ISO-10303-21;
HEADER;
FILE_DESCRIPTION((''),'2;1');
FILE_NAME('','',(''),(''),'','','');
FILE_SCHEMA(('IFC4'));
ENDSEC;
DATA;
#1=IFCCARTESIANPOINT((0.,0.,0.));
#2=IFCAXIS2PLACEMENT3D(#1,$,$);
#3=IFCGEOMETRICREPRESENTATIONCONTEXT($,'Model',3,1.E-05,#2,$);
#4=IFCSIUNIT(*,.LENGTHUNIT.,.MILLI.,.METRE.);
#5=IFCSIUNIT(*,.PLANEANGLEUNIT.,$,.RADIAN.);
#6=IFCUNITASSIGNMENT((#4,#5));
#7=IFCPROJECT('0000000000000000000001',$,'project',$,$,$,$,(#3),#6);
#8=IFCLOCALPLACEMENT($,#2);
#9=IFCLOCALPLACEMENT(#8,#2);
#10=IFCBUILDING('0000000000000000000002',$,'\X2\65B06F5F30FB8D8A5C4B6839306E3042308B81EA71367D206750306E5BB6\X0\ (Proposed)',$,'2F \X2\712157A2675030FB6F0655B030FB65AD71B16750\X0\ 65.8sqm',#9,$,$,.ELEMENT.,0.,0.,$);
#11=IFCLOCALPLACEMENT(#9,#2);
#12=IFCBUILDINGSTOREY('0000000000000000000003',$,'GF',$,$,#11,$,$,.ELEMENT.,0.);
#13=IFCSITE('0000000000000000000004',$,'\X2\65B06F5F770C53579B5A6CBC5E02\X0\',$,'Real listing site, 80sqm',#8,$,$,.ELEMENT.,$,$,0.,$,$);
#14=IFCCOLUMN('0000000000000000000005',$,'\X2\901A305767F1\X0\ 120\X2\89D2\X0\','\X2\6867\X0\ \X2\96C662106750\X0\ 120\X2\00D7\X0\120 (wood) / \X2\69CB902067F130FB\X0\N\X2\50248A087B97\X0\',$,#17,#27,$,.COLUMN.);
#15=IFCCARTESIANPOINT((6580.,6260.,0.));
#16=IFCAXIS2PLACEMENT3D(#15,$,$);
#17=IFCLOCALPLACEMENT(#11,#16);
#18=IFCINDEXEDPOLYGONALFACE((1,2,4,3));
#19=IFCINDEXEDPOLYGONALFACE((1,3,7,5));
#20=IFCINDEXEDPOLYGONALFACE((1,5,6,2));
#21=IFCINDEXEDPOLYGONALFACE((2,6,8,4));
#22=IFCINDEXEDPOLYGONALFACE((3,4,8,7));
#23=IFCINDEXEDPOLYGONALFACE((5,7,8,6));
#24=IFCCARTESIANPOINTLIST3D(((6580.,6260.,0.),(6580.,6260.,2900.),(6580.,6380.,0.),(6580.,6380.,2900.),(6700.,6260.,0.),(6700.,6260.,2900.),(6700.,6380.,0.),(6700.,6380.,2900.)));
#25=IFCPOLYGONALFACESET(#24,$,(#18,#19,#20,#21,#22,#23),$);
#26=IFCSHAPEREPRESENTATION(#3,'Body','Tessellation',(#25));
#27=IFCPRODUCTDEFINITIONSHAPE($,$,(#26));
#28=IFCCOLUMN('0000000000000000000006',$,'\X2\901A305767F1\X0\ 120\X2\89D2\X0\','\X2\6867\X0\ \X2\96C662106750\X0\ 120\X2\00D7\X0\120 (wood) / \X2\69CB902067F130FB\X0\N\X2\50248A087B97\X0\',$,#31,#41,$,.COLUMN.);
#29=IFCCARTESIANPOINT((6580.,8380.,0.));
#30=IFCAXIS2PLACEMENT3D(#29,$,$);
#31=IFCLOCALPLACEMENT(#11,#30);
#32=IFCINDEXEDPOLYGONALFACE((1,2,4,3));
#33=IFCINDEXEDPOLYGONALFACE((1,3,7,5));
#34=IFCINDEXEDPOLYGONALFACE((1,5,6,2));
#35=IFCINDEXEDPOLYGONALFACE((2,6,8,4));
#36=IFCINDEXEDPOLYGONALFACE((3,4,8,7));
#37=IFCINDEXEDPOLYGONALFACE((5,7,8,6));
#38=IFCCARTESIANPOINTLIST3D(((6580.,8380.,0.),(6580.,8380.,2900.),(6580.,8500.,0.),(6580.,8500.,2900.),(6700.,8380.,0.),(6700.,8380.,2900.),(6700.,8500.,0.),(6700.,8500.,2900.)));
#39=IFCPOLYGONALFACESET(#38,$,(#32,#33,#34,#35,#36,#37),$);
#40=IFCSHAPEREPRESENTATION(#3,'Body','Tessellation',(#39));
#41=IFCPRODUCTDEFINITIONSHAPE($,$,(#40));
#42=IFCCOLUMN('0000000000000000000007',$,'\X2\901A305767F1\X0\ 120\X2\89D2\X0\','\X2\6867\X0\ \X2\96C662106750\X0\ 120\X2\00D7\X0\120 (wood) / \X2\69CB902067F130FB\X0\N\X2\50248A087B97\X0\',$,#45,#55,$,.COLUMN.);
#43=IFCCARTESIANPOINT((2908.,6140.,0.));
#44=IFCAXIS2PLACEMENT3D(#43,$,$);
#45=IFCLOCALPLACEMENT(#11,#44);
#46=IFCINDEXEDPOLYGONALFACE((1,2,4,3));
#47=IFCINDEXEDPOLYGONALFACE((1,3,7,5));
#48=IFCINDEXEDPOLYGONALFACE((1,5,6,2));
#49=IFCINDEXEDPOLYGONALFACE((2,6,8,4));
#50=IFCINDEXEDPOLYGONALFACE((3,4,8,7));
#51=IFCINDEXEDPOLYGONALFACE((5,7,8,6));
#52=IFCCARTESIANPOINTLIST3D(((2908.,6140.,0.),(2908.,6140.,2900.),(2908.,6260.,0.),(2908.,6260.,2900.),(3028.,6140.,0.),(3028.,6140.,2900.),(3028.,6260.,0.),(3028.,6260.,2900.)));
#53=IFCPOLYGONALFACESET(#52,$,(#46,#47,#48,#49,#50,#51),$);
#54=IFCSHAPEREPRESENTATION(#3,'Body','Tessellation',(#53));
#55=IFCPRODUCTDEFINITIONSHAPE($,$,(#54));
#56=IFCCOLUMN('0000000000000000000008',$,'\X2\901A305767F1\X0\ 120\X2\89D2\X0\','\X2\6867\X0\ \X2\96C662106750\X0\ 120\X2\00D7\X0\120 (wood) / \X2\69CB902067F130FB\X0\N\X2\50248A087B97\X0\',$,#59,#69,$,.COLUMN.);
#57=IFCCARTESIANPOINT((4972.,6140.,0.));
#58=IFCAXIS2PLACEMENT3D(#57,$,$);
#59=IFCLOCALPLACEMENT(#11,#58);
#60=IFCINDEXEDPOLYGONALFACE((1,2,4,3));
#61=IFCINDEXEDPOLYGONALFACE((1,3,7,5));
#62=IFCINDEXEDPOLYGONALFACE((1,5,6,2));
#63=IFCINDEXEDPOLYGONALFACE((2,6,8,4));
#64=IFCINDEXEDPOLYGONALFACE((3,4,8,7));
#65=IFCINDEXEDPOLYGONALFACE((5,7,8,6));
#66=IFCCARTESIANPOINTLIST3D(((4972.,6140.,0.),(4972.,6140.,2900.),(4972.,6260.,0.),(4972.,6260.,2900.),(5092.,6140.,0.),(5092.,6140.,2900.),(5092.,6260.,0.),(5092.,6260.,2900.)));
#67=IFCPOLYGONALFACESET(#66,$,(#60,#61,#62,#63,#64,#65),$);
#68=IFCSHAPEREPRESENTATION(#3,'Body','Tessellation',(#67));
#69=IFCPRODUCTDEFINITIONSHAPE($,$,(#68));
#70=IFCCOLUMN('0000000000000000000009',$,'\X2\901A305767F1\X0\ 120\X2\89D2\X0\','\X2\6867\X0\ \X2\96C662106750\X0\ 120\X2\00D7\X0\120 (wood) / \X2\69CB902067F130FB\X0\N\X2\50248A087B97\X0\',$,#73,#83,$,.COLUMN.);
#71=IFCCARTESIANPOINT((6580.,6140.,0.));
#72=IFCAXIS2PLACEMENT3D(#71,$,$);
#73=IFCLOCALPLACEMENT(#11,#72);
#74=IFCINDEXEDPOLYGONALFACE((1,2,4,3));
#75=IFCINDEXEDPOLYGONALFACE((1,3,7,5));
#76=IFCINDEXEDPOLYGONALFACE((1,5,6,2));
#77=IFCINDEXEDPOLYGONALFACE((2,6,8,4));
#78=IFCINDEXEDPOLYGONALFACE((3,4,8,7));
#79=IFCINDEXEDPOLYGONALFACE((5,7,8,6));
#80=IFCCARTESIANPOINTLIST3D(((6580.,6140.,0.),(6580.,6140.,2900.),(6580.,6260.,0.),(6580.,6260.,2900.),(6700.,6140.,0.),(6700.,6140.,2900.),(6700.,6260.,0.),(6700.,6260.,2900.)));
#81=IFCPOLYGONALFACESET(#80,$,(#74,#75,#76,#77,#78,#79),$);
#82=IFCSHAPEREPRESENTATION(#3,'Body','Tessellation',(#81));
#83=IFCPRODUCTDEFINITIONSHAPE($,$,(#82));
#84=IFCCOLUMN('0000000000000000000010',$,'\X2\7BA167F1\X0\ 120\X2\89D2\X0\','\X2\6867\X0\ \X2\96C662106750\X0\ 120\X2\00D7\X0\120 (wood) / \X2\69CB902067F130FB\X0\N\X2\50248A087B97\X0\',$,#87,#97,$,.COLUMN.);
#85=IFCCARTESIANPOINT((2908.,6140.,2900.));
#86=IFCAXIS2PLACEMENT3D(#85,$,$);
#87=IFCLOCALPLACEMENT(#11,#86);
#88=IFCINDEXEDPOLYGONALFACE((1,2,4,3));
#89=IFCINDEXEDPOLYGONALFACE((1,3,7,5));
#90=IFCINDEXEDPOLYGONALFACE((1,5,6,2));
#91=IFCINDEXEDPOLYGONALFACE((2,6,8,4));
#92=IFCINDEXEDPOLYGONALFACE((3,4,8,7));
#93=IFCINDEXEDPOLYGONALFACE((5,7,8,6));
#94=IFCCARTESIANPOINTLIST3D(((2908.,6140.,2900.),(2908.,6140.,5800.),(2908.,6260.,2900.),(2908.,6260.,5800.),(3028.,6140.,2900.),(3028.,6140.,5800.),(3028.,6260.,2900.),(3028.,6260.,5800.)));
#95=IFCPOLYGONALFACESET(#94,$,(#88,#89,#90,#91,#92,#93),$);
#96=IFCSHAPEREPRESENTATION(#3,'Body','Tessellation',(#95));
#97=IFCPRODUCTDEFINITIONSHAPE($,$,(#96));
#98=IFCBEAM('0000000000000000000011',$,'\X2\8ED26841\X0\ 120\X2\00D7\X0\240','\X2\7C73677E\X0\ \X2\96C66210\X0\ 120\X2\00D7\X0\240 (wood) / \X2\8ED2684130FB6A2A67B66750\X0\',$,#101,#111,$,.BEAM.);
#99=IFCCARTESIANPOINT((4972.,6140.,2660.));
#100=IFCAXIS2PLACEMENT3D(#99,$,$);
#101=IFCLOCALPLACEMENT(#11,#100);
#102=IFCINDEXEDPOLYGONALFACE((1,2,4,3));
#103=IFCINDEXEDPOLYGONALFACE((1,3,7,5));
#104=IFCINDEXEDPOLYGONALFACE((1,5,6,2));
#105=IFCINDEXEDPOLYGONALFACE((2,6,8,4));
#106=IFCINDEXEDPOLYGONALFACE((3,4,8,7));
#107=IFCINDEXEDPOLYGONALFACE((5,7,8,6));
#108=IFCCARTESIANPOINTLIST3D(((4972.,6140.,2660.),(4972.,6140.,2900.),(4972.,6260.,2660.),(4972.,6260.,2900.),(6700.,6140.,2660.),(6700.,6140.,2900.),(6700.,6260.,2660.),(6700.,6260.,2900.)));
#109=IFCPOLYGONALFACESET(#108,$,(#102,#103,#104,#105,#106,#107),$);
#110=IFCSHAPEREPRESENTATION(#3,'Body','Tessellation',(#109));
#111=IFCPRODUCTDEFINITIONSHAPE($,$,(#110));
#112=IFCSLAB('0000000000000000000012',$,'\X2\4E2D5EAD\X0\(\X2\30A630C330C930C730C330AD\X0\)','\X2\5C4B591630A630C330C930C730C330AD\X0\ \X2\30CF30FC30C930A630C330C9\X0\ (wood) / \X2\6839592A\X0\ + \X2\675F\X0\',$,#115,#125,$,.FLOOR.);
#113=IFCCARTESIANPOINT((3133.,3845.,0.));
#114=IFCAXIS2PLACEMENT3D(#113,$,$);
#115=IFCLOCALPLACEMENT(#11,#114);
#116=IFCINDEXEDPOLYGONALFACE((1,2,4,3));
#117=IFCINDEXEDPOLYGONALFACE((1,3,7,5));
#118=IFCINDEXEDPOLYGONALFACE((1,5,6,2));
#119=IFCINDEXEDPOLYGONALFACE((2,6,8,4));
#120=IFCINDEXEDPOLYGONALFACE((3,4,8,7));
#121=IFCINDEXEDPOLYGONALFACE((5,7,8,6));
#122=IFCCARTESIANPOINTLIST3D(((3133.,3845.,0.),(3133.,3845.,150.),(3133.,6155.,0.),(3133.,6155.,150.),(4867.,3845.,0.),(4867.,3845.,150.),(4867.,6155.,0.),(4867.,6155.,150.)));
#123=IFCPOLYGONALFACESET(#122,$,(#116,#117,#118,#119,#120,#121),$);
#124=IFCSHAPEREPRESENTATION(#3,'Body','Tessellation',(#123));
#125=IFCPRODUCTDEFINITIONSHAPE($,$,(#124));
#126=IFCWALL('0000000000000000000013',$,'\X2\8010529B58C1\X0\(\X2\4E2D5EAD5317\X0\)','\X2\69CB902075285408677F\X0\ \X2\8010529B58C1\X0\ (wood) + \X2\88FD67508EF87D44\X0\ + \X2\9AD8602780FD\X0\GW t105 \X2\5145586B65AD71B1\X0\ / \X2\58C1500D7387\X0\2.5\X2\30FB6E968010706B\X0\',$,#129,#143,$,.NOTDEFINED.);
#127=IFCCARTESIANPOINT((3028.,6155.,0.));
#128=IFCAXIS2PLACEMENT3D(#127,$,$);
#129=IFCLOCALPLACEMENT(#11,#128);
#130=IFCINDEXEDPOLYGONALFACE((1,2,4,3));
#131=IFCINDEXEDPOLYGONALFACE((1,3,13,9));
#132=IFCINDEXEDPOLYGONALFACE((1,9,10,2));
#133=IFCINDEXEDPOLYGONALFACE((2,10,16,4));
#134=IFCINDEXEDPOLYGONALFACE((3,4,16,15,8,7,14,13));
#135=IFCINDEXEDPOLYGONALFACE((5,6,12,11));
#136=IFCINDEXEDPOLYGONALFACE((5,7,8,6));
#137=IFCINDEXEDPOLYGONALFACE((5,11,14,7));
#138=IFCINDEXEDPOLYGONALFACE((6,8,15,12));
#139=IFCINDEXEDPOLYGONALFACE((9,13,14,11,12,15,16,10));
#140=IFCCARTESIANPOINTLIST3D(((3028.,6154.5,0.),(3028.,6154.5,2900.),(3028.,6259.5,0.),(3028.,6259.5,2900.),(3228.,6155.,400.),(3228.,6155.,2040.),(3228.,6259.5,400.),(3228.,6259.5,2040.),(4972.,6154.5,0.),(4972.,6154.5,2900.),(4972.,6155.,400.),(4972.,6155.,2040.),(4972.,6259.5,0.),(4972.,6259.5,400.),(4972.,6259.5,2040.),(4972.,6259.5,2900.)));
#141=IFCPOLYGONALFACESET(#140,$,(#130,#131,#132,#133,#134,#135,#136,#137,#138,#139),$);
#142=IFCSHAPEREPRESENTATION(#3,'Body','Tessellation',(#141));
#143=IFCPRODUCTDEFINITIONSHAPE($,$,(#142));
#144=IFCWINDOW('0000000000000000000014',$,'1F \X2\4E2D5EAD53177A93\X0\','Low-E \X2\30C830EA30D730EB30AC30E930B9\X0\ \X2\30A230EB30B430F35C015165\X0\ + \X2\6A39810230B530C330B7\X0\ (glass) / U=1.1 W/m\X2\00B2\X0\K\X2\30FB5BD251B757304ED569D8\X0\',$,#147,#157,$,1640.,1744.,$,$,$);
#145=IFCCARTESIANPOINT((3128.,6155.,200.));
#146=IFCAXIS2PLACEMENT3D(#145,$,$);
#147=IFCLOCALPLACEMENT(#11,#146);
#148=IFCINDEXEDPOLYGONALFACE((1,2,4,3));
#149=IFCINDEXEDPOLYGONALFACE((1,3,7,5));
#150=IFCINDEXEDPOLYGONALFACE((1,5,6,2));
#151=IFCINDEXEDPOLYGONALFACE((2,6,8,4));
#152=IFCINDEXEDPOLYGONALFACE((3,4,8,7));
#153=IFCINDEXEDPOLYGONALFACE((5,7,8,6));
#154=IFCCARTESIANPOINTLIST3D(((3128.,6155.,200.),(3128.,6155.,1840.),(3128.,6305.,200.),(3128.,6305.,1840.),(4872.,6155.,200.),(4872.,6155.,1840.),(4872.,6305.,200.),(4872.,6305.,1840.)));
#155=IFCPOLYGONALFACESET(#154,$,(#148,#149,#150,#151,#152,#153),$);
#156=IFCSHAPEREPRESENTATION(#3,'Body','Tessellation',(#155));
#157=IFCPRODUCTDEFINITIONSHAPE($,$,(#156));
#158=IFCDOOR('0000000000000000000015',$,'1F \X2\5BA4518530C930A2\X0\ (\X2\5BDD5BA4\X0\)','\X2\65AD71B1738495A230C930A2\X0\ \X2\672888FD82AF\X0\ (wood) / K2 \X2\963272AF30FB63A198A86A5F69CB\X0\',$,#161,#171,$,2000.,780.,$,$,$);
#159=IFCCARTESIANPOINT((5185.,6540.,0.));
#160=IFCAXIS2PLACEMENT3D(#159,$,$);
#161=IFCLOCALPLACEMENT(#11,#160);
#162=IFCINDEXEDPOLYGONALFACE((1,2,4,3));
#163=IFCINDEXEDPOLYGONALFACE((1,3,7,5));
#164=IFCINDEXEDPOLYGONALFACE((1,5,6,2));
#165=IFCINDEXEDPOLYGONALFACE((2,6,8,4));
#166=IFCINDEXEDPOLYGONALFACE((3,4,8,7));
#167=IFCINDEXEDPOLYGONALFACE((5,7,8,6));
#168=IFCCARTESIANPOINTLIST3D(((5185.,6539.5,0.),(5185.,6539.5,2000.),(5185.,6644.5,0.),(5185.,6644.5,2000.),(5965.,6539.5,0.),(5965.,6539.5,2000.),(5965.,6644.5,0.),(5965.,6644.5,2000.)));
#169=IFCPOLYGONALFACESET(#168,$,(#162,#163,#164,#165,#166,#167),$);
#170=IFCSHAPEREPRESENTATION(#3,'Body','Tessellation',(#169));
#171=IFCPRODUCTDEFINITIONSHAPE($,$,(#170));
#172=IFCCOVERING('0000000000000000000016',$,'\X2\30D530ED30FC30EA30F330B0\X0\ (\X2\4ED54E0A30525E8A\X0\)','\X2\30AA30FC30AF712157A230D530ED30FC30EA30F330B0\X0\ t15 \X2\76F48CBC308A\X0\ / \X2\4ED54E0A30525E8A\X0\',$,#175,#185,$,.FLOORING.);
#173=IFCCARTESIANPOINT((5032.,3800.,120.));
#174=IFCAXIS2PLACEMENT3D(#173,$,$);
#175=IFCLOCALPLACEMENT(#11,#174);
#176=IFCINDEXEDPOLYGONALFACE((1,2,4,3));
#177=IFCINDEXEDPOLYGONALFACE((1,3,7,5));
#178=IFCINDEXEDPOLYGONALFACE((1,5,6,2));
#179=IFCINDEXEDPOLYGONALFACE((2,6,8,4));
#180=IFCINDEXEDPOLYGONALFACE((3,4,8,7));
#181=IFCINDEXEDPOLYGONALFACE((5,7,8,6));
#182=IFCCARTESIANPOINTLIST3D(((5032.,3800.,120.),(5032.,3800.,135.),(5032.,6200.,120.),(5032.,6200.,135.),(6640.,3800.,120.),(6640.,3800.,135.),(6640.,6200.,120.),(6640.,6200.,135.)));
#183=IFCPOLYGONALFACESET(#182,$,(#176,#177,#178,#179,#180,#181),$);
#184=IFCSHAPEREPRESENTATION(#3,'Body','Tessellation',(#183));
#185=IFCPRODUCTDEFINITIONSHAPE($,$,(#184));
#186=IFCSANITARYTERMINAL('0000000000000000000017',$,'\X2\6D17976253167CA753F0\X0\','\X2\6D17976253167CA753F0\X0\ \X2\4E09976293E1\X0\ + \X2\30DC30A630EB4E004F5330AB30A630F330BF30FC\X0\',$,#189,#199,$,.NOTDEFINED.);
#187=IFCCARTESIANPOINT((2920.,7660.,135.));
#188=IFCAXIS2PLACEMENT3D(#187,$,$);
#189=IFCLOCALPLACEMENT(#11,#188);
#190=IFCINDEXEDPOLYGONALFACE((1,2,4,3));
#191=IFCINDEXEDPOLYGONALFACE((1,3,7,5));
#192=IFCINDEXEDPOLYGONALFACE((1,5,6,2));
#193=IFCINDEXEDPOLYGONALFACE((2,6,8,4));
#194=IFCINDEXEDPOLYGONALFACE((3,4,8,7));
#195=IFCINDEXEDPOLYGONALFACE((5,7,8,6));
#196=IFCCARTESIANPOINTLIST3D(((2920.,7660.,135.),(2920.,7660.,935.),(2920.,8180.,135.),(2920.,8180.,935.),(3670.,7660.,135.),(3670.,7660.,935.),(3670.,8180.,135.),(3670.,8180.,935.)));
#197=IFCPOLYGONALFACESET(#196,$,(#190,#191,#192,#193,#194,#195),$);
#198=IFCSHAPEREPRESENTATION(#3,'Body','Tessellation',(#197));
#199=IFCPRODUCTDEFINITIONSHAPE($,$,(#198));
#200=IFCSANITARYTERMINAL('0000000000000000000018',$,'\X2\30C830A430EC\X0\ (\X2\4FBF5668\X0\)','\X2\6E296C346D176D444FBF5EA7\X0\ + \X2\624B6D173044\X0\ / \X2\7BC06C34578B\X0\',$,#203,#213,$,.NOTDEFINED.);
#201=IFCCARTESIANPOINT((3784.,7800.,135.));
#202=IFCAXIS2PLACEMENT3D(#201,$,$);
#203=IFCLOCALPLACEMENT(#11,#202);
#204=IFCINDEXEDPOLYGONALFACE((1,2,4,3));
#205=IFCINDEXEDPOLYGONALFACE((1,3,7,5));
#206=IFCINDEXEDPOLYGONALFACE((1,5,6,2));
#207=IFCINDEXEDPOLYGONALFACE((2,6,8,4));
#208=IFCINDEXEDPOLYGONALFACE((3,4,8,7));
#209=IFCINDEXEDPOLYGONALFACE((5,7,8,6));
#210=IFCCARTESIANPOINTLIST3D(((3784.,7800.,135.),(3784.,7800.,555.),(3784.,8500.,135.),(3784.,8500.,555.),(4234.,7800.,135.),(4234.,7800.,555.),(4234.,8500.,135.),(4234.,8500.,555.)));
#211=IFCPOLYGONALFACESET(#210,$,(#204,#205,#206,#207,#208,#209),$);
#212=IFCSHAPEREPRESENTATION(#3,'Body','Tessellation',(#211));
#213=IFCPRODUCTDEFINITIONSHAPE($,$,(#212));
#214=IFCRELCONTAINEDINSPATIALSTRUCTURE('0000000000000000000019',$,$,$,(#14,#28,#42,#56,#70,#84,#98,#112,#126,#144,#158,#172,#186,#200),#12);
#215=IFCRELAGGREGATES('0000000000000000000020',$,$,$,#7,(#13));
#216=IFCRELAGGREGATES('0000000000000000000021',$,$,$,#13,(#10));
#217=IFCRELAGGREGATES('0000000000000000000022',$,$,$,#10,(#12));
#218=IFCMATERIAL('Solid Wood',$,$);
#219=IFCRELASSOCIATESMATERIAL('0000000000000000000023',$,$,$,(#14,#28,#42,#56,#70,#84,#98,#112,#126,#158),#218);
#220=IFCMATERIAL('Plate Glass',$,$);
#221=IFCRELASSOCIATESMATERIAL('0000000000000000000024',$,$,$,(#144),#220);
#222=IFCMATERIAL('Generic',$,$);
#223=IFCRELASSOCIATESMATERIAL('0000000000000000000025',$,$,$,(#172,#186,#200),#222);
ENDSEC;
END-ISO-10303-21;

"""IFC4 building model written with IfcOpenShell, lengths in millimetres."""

from ifc_helpers import new_model, si_unit, frame, frame_2d, origin, place, context, project, spatial, rectangle, extrude, material, element, fill, save


model = new_model("IFC4")

# Units and contexts
model_context = context("Model", 3, precision=1e-05, world=origin())
ifc_project = project(units=[si_unit("LENGTHUNIT", "METRE", prefix="MILLI"), si_unit("PLANEANGLEUNIT", "RADIAN")], contexts=[model_context])

# Site, building, storey
site_placement = place(None, origin())
site = spatial("IfcSite", under=ifc_project, at=site_placement, Name="新潟県南魚沼市", ObjectType="Real listing site, 80sqm", CompositionType="ELEMENT", RefElevation=0.0)
building_placement = place(site_placement, origin())
building = spatial("IfcBuilding", under=site, at=building_placement, Name="新潟・越屋根のある自然素材の家 (Proposed)", ObjectType="2F 無垢材・漆喰・断熱材 65.8sqm", CompositionType="ELEMENT", ElevationOfRefHeight=0.0, ElevationOfTerrain=0.0)
storey_placement = place(building_placement, origin())
storey = spatial("IfcBuildingStorey", under=building, at=storey_placement, Name="GF", CompositionType="ELEMENT", Elevation=0.0)

# Columns
ifc_material_1 = material(Name="Solid Wood")
column_1_placement = place(storey_placement, frame((6580.0, 6260.0, 0.0)))
element("IfcColumn", 1, at=column_1_placement, inside=storey, material=ifc_material_1, Name="通し柱 120角", Description="桧 集成材 120×120 (wood) / 構造柱・N値計算", PredefinedType="COLUMN", context=model_context, shape_type="SweptSolid", body=[
    extrude(rectangle(XDim=120.0, YDim=120.0, at=frame_2d((60.0, 60.0))), frame((6580.0, 6260.0, 0.0)), (0.0, 0.0, 1.0), 2900.0),
])
column_2_placement = place(storey_placement, frame((6580.0, 8380.0, 0.0)))
element("IfcColumn", 2, at=column_2_placement, inside=storey, material=ifc_material_1, Name="通し柱 120角", Description="桧 集成材 120×120 (wood) / 構造柱・N値計算", PredefinedType="COLUMN", context=model_context, shape_type="SweptSolid", body=[
    extrude(rectangle(XDim=120.0, YDim=120.0, at=frame_2d((60.0, 60.0))), frame((6580.0, 8380.0, 0.0)), (0.0, 0.0, 1.0), 2900.0),
])
column_3_placement = place(storey_placement, frame((2908.0, 6140.0, 0.0)))
element("IfcColumn", 3, at=column_3_placement, inside=storey, material=ifc_material_1, Name="通し柱 120角", Description="桧 集成材 120×120 (wood) / 構造柱・N値計算", PredefinedType="COLUMN", context=model_context, shape_type="SweptSolid", body=[
    extrude(rectangle(XDim=120.0, YDim=120.0, at=frame_2d((60.0, 60.0))), frame((2908.0, 6140.0, 0.0)), (0.0, 0.0, 1.0), 2900.0),
])
column_4_placement = place(storey_placement, frame((4972.0, 6140.0, 0.0)))
element("IfcColumn", 4, at=column_4_placement, inside=storey, material=ifc_material_1, Name="通し柱 120角", Description="桧 集成材 120×120 (wood) / 構造柱・N値計算", PredefinedType="COLUMN", context=model_context, shape_type="SweptSolid", body=[
    extrude(rectangle(XDim=120.0, YDim=120.0, at=frame_2d((60.0, 60.0))), frame((4972.0, 6140.0, 0.0)), (0.0, 0.0, 1.0), 2900.0),
])
column_5_placement = place(storey_placement, frame((6580.0, 6140.0, 0.0)))
element("IfcColumn", 5, at=column_5_placement, inside=storey, material=ifc_material_1, Name="通し柱 120角", Description="桧 集成材 120×120 (wood) / 構造柱・N値計算", PredefinedType="COLUMN", context=model_context, shape_type="SweptSolid", body=[
    extrude(rectangle(XDim=120.0, YDim=120.0, at=frame_2d((60.0, 60.0))), frame((6580.0, 6140.0, 0.0)), (0.0, 0.0, 1.0), 2900.0),
])
column_6_placement = place(storey_placement, frame((2908.0, 6140.0, 2900.0)))
element("IfcColumn", 6, at=column_6_placement, inside=storey, material=ifc_material_1, Name="管柱 120角", Description="桧 集成材 120×120 (wood) / 構造柱・N値計算", PredefinedType="COLUMN", context=model_context, shape_type="SweptSolid", body=[
    extrude(rectangle(XDim=120.0, YDim=120.0, at=frame_2d((60.0, 60.0))), frame((2908.0, 6140.0, 2900.0)), (0.0, 0.0, 1.0), 2900.0),
])

# Beam
beam_1_placement = place(storey_placement, frame((4972.0, 6140.0, 2660.0)))
element("IfcBeam", 7, at=beam_1_placement, inside=storey, material=ifc_material_1, Name="軒桁 120×240", Description="米松 集成 120×240 (wood) / 軒桁・横架材", PredefinedType="BEAM", context=model_context, shape_type="SweptSolid", body=[
    extrude(rectangle(XDim=1728.0, YDim=120.0, at=frame_2d((864.0, 60.0))), frame((4972.0, 6140.0, 2660.0)), (0.0, 0.0, 1.0), 240.0),
])

# Slab
slab_placement = place(storey_placement, frame((3133.0, 3845.0, 0.0)))
element("IfcSlab", 8, at=slab_placement, inside=storey, material=ifc_material_1, Name="中庭(ウッドデッキ)", Description="屋外ウッドデッキ ハードウッド (wood) / 根太 + 束", PredefinedType="FLOOR", context=model_context, shape_type="SweptSolid", body=[
    extrude(rectangle(XDim=1734.0, YDim=2310.0, at=frame_2d((867.0, 1155.0))), frame((3133.0, 3845.0, 0.0)), (0.0, 0.0, 1.0), 150.0),
])

# Wall, opening, window
wall_1_placement = place(storey_placement, frame((3028.0, 6155.0, 0.0)))
wall_1 = element("IfcWall", 9, at=wall_1_placement, inside=storey, material=ifc_material_1, Name="耐力壁(中庭北)", Description="構造用合板 耐力壁 (wood) + 製材軸組 + 高性能GW t105 充填断熱 / 壁倍率2.5・準耐火", PredefinedType="NOTDEFINED", context=model_context, shape_type="SweptSolid", body=[
    extrude(rectangle(XDim=1944.0, YDim=105.0, at=frame_2d((972.0, 52.0))), frame((3028.0, 6155.0, 0.0)), (0.0, 0.0, 1.0), 2900.0),
])
opening_placement = place(storey_placement, frame((3128.0, 6155.0, 200.0)))
opening = element("IfcOpeningElement", 10, at=opening_placement, cuts=wall_1, PredefinedType="NOTDEFINED", context=model_context, shape_type="SweptSolid", body=[
    extrude(rectangle(XDim=1744.0, YDim=150.0, at=frame_2d((872.0, 75.0))), frame((3128.0, 6155.0, 200.0)), (0.0, 0.0, 1.0), 1640.0),
])
ifc_material_2 = material(Name="Plate Glass")
window_placement = place(storey_placement, frame((3128.0, 6155.0, 200.0)))
window = element("IfcWindow", 11, at=window_placement, inside=storey, material=ifc_material_2, Name="1F 中庭北窓", Description="Low-E トリプルガラス アルゴン封入 + 樹脂サッシ (glass) / U=1.1 W/m²K・寒冷地仕様", OverallHeight=1640.0, OverallWidth=1744.0, context=model_context, shape_type="SweptSolid", body=[
    extrude(rectangle(XDim=1744.0, YDim=150.0, at=frame_2d((872.0, 75.0))), frame((3128.0, 6155.0, 200.0)), (0.0, 0.0, 1.0), 1640.0),
])
fill(opening, window)

# Door
door_placement = place(storey_placement, frame((5185.0, 6540.0, 0.0)))
element("IfcDoor", 12, at=door_placement, inside=storey, material=ifc_material_1, Name="1F 室内ドア (寝室)", Description="断熱玄関ドア 木製芯 (wood) / K2 防犯・採風機構", OverallHeight=2000.0, OverallWidth=780.0, context=model_context, shape_type="SweptSolid", body=[
    extrude(rectangle(XDim=780.0, YDim=105.0, at=frame_2d((390.0, 52.0))), frame((5185.0, 6540.0, 0.0)), (0.0, 0.0, 1.0), 2000.0),
])

# Covering
ifc_material_3 = material(Name="Generic")
covering_placement = place(storey_placement, frame((5032.0, 3800.0, 120.0)))
element("IfcCovering", 13, at=covering_placement, inside=storey, material=ifc_material_3, Name="フローリング (仕上げ床)", Description="オーク無垢フローリング t15 直貼り / 仕上げ床", PredefinedType="FLOORING", context=model_context, shape_type="SweptSolid", body=[
    extrude(rectangle(XDim=1608.0, YDim=2400.0, at=frame_2d((804.0, 1200.0))), frame((5032.0, 3800.0, 120.0)), (0.0, 0.0, 1.0), 15.0),
])

# Sanitary terminals
sanitary_terminal_1_placement = place(storey_placement, frame((2920.0, 7660.0, 135.0)))
element("IfcSanitaryTerminal", 14, at=sanitary_terminal_1_placement, inside=storey, material=ifc_material_3, Name="洗面化粧台", Description="洗面化粧台 三面鏡 + ボウル一体カウンター", PredefinedType="NOTDEFINED", context=model_context, shape_type="SweptSolid", body=[
    extrude(rectangle(XDim=750.0, YDim=520.0, at=frame_2d((375.0, 260.0))), frame((2920.0, 7660.0, 135.0)), (0.0, 0.0, 1.0), 800.0),
])
sanitary_terminal_2_placement = place(storey_placement, frame((3784.0, 7800.0, 135.0)))
element("IfcSanitaryTerminal", 15, at=sanitary_terminal_2_placement, inside=storey, material=ifc_material_3, Name="トイレ (便器)", Description="温水洗浄便座 + 手洗い / 節水型", PredefinedType="NOTDEFINED", context=model_context, shape_type="SweptSolid", body=[
    extrude(rectangle(XDim=450.0, YDim=700.0, at=frame_2d((225.0, 350.0))), frame((3784.0, 7800.0, 135.0)), (0.0, 0.0, 1.0), 420.0),
])

save(model, "model.ifc")
